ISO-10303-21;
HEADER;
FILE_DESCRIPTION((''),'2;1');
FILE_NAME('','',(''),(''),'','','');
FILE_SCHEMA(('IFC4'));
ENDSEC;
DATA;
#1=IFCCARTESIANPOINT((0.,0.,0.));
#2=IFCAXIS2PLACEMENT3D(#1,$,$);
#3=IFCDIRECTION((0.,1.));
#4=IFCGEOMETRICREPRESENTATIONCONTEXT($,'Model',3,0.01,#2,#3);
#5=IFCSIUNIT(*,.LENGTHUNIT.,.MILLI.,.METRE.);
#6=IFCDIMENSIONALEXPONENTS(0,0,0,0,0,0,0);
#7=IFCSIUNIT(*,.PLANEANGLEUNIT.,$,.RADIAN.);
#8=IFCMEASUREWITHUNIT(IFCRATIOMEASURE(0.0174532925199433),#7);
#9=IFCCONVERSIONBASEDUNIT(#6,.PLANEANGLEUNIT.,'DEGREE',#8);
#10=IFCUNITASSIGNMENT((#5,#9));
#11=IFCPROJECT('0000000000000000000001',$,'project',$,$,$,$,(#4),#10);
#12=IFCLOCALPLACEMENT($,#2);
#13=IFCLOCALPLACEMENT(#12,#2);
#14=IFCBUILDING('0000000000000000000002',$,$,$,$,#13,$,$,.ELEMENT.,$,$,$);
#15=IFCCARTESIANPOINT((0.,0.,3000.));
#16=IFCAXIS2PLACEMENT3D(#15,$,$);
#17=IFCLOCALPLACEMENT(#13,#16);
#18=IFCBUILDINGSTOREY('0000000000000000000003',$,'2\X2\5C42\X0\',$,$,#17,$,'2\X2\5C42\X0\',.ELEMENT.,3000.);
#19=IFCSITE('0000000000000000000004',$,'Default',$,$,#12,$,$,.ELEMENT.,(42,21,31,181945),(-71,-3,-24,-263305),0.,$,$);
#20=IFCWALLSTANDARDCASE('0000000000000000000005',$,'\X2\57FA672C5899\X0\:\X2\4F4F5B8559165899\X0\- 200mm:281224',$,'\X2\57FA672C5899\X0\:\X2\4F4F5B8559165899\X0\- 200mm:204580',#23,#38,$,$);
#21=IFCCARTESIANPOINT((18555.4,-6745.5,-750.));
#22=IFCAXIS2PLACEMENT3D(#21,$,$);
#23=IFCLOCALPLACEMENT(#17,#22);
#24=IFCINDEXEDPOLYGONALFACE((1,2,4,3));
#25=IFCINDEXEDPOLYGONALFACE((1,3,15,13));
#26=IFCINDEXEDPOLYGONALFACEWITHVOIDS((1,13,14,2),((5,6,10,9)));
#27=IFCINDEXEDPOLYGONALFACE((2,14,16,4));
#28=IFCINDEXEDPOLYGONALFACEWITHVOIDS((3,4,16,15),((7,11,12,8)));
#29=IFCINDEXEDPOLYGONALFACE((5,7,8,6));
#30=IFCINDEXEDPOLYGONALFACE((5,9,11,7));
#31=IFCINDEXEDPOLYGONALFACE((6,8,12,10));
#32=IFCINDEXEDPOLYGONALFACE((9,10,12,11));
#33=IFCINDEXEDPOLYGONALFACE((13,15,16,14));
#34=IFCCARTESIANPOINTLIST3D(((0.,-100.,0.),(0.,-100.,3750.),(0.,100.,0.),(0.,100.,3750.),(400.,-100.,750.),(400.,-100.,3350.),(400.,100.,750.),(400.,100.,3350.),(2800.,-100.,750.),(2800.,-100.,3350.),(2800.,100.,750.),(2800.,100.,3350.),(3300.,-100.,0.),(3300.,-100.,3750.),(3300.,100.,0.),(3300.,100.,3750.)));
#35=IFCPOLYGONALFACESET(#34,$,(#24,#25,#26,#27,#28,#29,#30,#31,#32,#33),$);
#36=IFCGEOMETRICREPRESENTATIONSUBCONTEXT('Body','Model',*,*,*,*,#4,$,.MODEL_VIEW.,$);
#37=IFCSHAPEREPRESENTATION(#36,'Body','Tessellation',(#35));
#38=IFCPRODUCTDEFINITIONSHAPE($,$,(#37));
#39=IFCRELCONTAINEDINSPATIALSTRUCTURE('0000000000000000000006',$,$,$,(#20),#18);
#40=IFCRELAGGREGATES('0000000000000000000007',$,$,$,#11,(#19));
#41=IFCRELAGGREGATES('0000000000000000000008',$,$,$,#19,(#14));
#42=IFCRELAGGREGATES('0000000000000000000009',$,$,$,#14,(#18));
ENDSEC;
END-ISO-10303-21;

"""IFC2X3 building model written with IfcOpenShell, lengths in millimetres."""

from ifc_helpers import new_model, entity, si_unit, converted_unit, direction, frame, frame_2d, origin, place, context, subcontext, project, spatial, polyline, rectangle, extrude, clip, bounded_halfspace, element, save


model = new_model("IFC2X3")

# Units and contexts
model_context = context("Model", 3, precision=0.01, world=origin(), true_north=direction((0.0, 1.0)))
body_context = subcontext(model_context, "Body", "Model", "MODEL_VIEW")
ifc_project = project(units=[si_unit("LENGTHUNIT", "METRE", prefix="MILLI"), converted_unit("PLANEANGLEUNIT", "DEGREE", entity("IfcRatioMeasure", 0.0174532925199433), si_unit("PLANEANGLEUNIT", "RADIAN"), dimensions=[0, 0, 0, 0, 0, 0, 0])], contexts=[model_context])

# Site, building, storey
site_placement = place(None, origin())
site = spatial("IfcSite", under=ifc_project, at=site_placement, Name="Default", CompositionType="ELEMENT", RefLatitude=(42, 21, 31, 181945), RefLongitude=(-71, -3, -24, -263305), RefElevation=0.0)
building_placement = place(site_placement, origin())
building = spatial("IfcBuilding", under=site, at=building_placement, CompositionType="ELEMENT")
storey_placement = place(building_placement, frame((0.0, 0.0, 3000.0)))
storey = spatial("IfcBuildingStorey", under=building, at=storey_placement, Name="2层", LongName="2层", CompositionType="ELEMENT", Elevation=3000.0)

# Wall, openings
wall_1_placement = place(storey_placement, frame((18555.4, -6745.5, -750.0)))
wall_1 = element("IfcWallStandardCase", 1, at=wall_1_placement, inside=storey, Name="基本墙:住宅外墙- 200mm:281224", ObjectType="基本墙:住宅外墙- 200mm:204580", context=body_context, shape_type="Clipping", body=[
    clip(extrude(rectangle(XDim=3300.0, YDim=200.0, at=frame_2d((1650.0, 0.0), x_axis=(-1.0, 0.0))), origin(), (0.0, 0.0, 1.0), 3750.0), bounded_halfspace(frame((0.0, -100.0, 0.0), z_axis=(-1.0, 0.0, 0.0), x_axis=(0.0, 0.0, -1.0)), False, frame((0.0, -100.0, 0.0), z_axis=(-1.0, 0.0, 0.0), x_axis=(0.0, 0.0, -1.0)), polyline([(0.0, 0.0), (-3750.0, 0.0), (-3750.0, -200.0), (0.0, -200.0), (0.0, 0.0)]))),
])
opening_1_placement = place(wall_1_placement, origin())
element("IfcOpeningElement", 2, at=opening_1_placement, cuts=wall_1, ObjectType="Opening", context=body_context, shape_type="SweptSolid", body=[
    extrude(rectangle(XDim=2600.0, YDim=2400.0, at=frame_2d((0.0, 0.0), x_axis=(0.0, 1.0))), frame((1600.0, -1424.0, 5050.0), z_axis=(0.0, 1.0, 0.0), x_axis=(-1.0, 0.0, 0.0)), (0.0, 0.0, 1.0), 3048.0),
])
opening_2_placement = place(wall_1_placement, origin())
element("IfcOpeningElement", 3, at=opening_2_placement, cuts=wall_1, ObjectType="Opening", context=body_context, shape_type="SweptSolid", body=[
    extrude(rectangle(XDim=2600.0, YDim=2400.0, at=frame_2d((0.0, 0.0), x_axis=(0.0, 1.0))), frame((1600.0, -1424.0, 2050.0), z_axis=(0.0, 1.0, 0.0), x_axis=(-1.0, 0.0, 0.0)), (0.0, 0.0, 1.0), 3048.0),
])

save(model, "model.ifc")
